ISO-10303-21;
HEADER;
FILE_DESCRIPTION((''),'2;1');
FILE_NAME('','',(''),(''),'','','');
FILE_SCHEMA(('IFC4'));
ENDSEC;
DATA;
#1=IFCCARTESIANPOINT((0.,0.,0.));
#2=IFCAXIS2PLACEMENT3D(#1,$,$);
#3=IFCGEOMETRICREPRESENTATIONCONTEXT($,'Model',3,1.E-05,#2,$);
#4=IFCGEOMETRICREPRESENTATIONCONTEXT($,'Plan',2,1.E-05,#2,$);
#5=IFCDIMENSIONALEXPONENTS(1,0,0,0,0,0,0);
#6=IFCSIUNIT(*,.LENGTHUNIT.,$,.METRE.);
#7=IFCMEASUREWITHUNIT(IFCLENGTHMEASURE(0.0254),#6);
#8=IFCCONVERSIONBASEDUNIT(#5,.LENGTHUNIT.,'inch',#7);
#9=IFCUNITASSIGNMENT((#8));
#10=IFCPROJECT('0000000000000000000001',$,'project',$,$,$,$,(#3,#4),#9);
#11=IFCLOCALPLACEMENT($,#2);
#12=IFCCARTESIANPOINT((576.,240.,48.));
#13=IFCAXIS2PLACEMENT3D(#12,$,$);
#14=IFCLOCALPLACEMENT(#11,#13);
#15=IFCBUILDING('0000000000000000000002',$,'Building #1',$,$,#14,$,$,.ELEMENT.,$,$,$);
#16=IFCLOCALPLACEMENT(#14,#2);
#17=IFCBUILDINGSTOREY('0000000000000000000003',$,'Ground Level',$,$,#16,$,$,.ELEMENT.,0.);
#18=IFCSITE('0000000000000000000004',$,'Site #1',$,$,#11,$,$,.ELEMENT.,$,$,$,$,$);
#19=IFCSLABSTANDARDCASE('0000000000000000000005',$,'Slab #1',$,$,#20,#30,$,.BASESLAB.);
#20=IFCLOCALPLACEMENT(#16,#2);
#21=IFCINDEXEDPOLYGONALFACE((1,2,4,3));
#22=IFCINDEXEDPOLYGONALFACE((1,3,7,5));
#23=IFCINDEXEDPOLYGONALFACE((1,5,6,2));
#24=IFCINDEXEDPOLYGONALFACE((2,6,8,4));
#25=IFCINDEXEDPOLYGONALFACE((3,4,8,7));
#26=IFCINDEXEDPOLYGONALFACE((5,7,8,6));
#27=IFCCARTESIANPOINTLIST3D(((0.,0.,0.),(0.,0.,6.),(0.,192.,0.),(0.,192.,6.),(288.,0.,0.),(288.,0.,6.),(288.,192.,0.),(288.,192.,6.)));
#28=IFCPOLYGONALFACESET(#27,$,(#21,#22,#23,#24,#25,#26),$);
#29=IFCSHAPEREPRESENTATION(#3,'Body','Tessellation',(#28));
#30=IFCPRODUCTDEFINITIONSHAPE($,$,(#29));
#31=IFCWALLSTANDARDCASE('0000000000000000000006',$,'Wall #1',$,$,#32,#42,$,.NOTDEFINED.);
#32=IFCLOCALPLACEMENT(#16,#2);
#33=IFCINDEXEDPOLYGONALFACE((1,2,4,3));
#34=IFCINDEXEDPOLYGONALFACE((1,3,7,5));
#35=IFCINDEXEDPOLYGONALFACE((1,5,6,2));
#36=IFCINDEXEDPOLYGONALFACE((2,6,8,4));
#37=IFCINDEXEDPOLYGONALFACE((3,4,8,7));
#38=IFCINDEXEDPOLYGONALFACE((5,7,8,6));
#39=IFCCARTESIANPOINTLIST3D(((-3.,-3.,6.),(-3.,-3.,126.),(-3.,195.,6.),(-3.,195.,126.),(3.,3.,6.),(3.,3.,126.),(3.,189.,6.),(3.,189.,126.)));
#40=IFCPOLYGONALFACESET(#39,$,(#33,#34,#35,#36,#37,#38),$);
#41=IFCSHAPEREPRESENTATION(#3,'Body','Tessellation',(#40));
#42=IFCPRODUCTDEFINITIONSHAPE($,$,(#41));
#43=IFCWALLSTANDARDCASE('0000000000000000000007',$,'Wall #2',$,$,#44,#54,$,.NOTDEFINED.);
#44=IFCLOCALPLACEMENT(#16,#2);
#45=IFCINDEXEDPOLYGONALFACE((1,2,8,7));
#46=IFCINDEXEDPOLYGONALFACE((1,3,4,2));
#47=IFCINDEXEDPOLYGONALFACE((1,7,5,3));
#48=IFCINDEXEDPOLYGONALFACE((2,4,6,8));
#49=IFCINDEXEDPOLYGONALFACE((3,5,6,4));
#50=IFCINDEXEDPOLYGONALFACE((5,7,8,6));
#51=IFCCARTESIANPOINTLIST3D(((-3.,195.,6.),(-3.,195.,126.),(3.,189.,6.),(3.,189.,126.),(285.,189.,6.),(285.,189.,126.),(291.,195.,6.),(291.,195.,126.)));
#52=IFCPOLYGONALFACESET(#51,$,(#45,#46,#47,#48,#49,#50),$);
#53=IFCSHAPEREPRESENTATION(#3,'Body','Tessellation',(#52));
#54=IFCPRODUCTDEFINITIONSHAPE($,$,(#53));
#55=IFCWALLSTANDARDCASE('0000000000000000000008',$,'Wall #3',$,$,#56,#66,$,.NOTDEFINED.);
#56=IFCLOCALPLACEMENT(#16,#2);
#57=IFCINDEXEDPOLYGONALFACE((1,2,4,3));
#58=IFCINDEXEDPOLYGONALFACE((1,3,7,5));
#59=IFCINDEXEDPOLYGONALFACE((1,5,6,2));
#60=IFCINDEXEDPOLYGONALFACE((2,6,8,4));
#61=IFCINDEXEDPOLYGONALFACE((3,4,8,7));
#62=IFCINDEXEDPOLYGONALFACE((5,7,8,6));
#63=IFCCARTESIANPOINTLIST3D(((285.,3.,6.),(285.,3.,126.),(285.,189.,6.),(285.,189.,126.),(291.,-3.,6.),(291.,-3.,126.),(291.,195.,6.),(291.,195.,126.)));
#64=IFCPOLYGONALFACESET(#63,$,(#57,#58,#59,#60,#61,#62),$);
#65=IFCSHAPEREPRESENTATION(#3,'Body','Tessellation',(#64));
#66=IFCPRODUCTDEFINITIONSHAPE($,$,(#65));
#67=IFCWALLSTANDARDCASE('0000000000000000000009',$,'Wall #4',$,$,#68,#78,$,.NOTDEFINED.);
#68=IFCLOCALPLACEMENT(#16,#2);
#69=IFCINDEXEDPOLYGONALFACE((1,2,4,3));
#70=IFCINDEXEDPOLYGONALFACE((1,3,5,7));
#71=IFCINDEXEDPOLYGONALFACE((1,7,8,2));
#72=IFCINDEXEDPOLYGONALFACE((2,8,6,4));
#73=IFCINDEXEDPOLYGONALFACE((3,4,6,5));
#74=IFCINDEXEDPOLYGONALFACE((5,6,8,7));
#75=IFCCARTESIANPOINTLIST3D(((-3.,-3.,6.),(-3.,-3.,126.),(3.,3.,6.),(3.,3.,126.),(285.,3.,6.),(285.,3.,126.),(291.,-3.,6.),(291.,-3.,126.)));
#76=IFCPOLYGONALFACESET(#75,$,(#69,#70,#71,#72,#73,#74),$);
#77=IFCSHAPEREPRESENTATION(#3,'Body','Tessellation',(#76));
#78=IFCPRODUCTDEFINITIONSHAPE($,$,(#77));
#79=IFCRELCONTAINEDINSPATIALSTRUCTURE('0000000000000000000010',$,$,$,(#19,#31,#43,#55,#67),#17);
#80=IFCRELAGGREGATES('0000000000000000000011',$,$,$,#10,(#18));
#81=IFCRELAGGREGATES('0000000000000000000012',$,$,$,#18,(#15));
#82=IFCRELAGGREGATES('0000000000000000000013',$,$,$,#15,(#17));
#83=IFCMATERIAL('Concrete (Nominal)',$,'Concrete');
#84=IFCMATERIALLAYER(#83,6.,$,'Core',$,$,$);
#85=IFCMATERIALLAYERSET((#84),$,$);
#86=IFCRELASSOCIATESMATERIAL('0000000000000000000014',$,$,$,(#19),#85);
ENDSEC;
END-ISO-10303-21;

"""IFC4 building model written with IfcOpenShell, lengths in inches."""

from ifc_helpers import new_model, entity, si_unit, converted_unit, frame, origin, place, context, project, spatial, polyline, outline, extrude, material, layer, layer_set, layer_usage, element, save


model = new_model("IFC4")

# Units and contexts
model_context = context("Model", 3, precision=1e-05, world=origin())
plan_context = context("Plan", 2, precision=1e-05, world=origin())
ifc_project = project(units=[converted_unit("LENGTHUNIT", "inch", entity("IfcLengthMeasure", 0.0254), si_unit("LENGTHUNIT", "METRE"), dimensions=[1, 0, 0, 0, 0, 0, 0])], contexts=[model_context, plan_context])

# Site, building, storey
site_placement = place(None, origin())
site = spatial("IfcSite", under=ifc_project, at=site_placement, Name="Site #1", CompositionType="ELEMENT")
building_placement = place(site_placement, frame((576.0, 240.0, 48.0)))
building = spatial("IfcBuilding", under=site, at=building_placement, Name="Building #1", CompositionType="ELEMENT")
storey_placement = place(building_placement, origin())
storey = spatial("IfcBuildingStorey", under=building, at=storey_placement, Name="Ground Level", CompositionType="ELEMENT", Elevation=0.0)

# Slab
ifc_material = material(Name="Concrete (Nominal)", Category="Concrete")
ifc_layer = layer(ifc_material, 6.0, Name="Core")
ifc_layer_set = layer_set([ifc_layer])
ifc_layer_usage = layer_usage(ifc_layer_set, "AXIS3", "POSITIVE", 0.0)
slab_placement = place(storey_placement, origin())
element("IfcSlabStandardCase", 1, at=slab_placement, inside=storey, material=ifc_layer_usage, Name="Slab #1", PredefinedType="BASESLAB", context=model_context, shape_type="SweptSolid", body=[
    extrude(outline(polyline([(0.0, 0.0), (288.0, 0.0), (288.0, 192.0), (0.0, 192.0), (0.0, 0.0)])), origin(), (0.0, 0.0, 1.0), 6.0),
])

# Walls
wall_1_placement = place(storey_placement, frame((0.0, 0.0, 6.0), z_axis=(0.0, 0.0, 1.0), x_axis=(0.0, 1.0, 0.0)))
element("IfcWallStandardCase", 2, at=wall_1_placement, inside=storey, Name="Wall #1", PredefinedType="NOTDEFINED", context=model_context, shape_type="SweptSolid", body=[
    extrude(outline(polyline([(3.0, -3.0), (189.0, -3.0), (195.0, 3.0), (-3.0, 3.0), (3.0, -3.0)])), origin(), (0.0, 0.0, 1.0), 120.0),
])
wall_2_placement = place(storey_placement, frame((0.0, 192.0, 6.0), z_axis=(0.0, 0.0, 1.0), x_axis=(1.0, 0.0, 0.0)))
element("IfcWallStandardCase", 3, at=wall_2_placement, inside=storey, Name="Wall #2", PredefinedType="NOTDEFINED", context=model_context, shape_type="SweptSolid", body=[
    extrude(outline(polyline([(3.0, -3.0), (285.0, -3.0), (291.0, 3.0), (-3.0, 3.0), (3.0, -3.0)])), origin(), (0.0, 0.0, 1.0), 120.0),
])
wall_3_placement = place(storey_placement, frame((288.0, 192.0, 6.0), z_axis=(0.0, 0.0, 1.0), x_axis=(0.0, -1.0, 0.0)))
element("IfcWallStandardCase", 4, at=wall_3_placement, inside=storey, Name="Wall #3", PredefinedType="NOTDEFINED", context=model_context, shape_type="SweptSolid", body=[
    extrude(outline(polyline([(3.0, -3.0), (189.0, -3.0), (195.0, 3.0), (-3.0, 3.0), (3.0, -3.0)])), origin(), (0.0, 0.0, 1.0), 120.0),
])
wall_4_placement = place(storey_placement, frame((288.0, 0.0, 6.0), z_axis=(0.0, 0.0, 1.0), x_axis=(-1.0, 0.0, 0.0)))
element("IfcWallStandardCase", 5, at=wall_4_placement, inside=storey, Name="Wall #4", PredefinedType="NOTDEFINED", context=model_context, shape_type="SweptSolid", body=[
    extrude(outline(polyline([(3.0, -3.0), (285.0, -3.0), (291.0, 3.0), (-3.0, 3.0), (3.0, -3.0)])), origin(), (0.0, 0.0, 1.0), 120.0),
])

save(model, "model.ifc")
